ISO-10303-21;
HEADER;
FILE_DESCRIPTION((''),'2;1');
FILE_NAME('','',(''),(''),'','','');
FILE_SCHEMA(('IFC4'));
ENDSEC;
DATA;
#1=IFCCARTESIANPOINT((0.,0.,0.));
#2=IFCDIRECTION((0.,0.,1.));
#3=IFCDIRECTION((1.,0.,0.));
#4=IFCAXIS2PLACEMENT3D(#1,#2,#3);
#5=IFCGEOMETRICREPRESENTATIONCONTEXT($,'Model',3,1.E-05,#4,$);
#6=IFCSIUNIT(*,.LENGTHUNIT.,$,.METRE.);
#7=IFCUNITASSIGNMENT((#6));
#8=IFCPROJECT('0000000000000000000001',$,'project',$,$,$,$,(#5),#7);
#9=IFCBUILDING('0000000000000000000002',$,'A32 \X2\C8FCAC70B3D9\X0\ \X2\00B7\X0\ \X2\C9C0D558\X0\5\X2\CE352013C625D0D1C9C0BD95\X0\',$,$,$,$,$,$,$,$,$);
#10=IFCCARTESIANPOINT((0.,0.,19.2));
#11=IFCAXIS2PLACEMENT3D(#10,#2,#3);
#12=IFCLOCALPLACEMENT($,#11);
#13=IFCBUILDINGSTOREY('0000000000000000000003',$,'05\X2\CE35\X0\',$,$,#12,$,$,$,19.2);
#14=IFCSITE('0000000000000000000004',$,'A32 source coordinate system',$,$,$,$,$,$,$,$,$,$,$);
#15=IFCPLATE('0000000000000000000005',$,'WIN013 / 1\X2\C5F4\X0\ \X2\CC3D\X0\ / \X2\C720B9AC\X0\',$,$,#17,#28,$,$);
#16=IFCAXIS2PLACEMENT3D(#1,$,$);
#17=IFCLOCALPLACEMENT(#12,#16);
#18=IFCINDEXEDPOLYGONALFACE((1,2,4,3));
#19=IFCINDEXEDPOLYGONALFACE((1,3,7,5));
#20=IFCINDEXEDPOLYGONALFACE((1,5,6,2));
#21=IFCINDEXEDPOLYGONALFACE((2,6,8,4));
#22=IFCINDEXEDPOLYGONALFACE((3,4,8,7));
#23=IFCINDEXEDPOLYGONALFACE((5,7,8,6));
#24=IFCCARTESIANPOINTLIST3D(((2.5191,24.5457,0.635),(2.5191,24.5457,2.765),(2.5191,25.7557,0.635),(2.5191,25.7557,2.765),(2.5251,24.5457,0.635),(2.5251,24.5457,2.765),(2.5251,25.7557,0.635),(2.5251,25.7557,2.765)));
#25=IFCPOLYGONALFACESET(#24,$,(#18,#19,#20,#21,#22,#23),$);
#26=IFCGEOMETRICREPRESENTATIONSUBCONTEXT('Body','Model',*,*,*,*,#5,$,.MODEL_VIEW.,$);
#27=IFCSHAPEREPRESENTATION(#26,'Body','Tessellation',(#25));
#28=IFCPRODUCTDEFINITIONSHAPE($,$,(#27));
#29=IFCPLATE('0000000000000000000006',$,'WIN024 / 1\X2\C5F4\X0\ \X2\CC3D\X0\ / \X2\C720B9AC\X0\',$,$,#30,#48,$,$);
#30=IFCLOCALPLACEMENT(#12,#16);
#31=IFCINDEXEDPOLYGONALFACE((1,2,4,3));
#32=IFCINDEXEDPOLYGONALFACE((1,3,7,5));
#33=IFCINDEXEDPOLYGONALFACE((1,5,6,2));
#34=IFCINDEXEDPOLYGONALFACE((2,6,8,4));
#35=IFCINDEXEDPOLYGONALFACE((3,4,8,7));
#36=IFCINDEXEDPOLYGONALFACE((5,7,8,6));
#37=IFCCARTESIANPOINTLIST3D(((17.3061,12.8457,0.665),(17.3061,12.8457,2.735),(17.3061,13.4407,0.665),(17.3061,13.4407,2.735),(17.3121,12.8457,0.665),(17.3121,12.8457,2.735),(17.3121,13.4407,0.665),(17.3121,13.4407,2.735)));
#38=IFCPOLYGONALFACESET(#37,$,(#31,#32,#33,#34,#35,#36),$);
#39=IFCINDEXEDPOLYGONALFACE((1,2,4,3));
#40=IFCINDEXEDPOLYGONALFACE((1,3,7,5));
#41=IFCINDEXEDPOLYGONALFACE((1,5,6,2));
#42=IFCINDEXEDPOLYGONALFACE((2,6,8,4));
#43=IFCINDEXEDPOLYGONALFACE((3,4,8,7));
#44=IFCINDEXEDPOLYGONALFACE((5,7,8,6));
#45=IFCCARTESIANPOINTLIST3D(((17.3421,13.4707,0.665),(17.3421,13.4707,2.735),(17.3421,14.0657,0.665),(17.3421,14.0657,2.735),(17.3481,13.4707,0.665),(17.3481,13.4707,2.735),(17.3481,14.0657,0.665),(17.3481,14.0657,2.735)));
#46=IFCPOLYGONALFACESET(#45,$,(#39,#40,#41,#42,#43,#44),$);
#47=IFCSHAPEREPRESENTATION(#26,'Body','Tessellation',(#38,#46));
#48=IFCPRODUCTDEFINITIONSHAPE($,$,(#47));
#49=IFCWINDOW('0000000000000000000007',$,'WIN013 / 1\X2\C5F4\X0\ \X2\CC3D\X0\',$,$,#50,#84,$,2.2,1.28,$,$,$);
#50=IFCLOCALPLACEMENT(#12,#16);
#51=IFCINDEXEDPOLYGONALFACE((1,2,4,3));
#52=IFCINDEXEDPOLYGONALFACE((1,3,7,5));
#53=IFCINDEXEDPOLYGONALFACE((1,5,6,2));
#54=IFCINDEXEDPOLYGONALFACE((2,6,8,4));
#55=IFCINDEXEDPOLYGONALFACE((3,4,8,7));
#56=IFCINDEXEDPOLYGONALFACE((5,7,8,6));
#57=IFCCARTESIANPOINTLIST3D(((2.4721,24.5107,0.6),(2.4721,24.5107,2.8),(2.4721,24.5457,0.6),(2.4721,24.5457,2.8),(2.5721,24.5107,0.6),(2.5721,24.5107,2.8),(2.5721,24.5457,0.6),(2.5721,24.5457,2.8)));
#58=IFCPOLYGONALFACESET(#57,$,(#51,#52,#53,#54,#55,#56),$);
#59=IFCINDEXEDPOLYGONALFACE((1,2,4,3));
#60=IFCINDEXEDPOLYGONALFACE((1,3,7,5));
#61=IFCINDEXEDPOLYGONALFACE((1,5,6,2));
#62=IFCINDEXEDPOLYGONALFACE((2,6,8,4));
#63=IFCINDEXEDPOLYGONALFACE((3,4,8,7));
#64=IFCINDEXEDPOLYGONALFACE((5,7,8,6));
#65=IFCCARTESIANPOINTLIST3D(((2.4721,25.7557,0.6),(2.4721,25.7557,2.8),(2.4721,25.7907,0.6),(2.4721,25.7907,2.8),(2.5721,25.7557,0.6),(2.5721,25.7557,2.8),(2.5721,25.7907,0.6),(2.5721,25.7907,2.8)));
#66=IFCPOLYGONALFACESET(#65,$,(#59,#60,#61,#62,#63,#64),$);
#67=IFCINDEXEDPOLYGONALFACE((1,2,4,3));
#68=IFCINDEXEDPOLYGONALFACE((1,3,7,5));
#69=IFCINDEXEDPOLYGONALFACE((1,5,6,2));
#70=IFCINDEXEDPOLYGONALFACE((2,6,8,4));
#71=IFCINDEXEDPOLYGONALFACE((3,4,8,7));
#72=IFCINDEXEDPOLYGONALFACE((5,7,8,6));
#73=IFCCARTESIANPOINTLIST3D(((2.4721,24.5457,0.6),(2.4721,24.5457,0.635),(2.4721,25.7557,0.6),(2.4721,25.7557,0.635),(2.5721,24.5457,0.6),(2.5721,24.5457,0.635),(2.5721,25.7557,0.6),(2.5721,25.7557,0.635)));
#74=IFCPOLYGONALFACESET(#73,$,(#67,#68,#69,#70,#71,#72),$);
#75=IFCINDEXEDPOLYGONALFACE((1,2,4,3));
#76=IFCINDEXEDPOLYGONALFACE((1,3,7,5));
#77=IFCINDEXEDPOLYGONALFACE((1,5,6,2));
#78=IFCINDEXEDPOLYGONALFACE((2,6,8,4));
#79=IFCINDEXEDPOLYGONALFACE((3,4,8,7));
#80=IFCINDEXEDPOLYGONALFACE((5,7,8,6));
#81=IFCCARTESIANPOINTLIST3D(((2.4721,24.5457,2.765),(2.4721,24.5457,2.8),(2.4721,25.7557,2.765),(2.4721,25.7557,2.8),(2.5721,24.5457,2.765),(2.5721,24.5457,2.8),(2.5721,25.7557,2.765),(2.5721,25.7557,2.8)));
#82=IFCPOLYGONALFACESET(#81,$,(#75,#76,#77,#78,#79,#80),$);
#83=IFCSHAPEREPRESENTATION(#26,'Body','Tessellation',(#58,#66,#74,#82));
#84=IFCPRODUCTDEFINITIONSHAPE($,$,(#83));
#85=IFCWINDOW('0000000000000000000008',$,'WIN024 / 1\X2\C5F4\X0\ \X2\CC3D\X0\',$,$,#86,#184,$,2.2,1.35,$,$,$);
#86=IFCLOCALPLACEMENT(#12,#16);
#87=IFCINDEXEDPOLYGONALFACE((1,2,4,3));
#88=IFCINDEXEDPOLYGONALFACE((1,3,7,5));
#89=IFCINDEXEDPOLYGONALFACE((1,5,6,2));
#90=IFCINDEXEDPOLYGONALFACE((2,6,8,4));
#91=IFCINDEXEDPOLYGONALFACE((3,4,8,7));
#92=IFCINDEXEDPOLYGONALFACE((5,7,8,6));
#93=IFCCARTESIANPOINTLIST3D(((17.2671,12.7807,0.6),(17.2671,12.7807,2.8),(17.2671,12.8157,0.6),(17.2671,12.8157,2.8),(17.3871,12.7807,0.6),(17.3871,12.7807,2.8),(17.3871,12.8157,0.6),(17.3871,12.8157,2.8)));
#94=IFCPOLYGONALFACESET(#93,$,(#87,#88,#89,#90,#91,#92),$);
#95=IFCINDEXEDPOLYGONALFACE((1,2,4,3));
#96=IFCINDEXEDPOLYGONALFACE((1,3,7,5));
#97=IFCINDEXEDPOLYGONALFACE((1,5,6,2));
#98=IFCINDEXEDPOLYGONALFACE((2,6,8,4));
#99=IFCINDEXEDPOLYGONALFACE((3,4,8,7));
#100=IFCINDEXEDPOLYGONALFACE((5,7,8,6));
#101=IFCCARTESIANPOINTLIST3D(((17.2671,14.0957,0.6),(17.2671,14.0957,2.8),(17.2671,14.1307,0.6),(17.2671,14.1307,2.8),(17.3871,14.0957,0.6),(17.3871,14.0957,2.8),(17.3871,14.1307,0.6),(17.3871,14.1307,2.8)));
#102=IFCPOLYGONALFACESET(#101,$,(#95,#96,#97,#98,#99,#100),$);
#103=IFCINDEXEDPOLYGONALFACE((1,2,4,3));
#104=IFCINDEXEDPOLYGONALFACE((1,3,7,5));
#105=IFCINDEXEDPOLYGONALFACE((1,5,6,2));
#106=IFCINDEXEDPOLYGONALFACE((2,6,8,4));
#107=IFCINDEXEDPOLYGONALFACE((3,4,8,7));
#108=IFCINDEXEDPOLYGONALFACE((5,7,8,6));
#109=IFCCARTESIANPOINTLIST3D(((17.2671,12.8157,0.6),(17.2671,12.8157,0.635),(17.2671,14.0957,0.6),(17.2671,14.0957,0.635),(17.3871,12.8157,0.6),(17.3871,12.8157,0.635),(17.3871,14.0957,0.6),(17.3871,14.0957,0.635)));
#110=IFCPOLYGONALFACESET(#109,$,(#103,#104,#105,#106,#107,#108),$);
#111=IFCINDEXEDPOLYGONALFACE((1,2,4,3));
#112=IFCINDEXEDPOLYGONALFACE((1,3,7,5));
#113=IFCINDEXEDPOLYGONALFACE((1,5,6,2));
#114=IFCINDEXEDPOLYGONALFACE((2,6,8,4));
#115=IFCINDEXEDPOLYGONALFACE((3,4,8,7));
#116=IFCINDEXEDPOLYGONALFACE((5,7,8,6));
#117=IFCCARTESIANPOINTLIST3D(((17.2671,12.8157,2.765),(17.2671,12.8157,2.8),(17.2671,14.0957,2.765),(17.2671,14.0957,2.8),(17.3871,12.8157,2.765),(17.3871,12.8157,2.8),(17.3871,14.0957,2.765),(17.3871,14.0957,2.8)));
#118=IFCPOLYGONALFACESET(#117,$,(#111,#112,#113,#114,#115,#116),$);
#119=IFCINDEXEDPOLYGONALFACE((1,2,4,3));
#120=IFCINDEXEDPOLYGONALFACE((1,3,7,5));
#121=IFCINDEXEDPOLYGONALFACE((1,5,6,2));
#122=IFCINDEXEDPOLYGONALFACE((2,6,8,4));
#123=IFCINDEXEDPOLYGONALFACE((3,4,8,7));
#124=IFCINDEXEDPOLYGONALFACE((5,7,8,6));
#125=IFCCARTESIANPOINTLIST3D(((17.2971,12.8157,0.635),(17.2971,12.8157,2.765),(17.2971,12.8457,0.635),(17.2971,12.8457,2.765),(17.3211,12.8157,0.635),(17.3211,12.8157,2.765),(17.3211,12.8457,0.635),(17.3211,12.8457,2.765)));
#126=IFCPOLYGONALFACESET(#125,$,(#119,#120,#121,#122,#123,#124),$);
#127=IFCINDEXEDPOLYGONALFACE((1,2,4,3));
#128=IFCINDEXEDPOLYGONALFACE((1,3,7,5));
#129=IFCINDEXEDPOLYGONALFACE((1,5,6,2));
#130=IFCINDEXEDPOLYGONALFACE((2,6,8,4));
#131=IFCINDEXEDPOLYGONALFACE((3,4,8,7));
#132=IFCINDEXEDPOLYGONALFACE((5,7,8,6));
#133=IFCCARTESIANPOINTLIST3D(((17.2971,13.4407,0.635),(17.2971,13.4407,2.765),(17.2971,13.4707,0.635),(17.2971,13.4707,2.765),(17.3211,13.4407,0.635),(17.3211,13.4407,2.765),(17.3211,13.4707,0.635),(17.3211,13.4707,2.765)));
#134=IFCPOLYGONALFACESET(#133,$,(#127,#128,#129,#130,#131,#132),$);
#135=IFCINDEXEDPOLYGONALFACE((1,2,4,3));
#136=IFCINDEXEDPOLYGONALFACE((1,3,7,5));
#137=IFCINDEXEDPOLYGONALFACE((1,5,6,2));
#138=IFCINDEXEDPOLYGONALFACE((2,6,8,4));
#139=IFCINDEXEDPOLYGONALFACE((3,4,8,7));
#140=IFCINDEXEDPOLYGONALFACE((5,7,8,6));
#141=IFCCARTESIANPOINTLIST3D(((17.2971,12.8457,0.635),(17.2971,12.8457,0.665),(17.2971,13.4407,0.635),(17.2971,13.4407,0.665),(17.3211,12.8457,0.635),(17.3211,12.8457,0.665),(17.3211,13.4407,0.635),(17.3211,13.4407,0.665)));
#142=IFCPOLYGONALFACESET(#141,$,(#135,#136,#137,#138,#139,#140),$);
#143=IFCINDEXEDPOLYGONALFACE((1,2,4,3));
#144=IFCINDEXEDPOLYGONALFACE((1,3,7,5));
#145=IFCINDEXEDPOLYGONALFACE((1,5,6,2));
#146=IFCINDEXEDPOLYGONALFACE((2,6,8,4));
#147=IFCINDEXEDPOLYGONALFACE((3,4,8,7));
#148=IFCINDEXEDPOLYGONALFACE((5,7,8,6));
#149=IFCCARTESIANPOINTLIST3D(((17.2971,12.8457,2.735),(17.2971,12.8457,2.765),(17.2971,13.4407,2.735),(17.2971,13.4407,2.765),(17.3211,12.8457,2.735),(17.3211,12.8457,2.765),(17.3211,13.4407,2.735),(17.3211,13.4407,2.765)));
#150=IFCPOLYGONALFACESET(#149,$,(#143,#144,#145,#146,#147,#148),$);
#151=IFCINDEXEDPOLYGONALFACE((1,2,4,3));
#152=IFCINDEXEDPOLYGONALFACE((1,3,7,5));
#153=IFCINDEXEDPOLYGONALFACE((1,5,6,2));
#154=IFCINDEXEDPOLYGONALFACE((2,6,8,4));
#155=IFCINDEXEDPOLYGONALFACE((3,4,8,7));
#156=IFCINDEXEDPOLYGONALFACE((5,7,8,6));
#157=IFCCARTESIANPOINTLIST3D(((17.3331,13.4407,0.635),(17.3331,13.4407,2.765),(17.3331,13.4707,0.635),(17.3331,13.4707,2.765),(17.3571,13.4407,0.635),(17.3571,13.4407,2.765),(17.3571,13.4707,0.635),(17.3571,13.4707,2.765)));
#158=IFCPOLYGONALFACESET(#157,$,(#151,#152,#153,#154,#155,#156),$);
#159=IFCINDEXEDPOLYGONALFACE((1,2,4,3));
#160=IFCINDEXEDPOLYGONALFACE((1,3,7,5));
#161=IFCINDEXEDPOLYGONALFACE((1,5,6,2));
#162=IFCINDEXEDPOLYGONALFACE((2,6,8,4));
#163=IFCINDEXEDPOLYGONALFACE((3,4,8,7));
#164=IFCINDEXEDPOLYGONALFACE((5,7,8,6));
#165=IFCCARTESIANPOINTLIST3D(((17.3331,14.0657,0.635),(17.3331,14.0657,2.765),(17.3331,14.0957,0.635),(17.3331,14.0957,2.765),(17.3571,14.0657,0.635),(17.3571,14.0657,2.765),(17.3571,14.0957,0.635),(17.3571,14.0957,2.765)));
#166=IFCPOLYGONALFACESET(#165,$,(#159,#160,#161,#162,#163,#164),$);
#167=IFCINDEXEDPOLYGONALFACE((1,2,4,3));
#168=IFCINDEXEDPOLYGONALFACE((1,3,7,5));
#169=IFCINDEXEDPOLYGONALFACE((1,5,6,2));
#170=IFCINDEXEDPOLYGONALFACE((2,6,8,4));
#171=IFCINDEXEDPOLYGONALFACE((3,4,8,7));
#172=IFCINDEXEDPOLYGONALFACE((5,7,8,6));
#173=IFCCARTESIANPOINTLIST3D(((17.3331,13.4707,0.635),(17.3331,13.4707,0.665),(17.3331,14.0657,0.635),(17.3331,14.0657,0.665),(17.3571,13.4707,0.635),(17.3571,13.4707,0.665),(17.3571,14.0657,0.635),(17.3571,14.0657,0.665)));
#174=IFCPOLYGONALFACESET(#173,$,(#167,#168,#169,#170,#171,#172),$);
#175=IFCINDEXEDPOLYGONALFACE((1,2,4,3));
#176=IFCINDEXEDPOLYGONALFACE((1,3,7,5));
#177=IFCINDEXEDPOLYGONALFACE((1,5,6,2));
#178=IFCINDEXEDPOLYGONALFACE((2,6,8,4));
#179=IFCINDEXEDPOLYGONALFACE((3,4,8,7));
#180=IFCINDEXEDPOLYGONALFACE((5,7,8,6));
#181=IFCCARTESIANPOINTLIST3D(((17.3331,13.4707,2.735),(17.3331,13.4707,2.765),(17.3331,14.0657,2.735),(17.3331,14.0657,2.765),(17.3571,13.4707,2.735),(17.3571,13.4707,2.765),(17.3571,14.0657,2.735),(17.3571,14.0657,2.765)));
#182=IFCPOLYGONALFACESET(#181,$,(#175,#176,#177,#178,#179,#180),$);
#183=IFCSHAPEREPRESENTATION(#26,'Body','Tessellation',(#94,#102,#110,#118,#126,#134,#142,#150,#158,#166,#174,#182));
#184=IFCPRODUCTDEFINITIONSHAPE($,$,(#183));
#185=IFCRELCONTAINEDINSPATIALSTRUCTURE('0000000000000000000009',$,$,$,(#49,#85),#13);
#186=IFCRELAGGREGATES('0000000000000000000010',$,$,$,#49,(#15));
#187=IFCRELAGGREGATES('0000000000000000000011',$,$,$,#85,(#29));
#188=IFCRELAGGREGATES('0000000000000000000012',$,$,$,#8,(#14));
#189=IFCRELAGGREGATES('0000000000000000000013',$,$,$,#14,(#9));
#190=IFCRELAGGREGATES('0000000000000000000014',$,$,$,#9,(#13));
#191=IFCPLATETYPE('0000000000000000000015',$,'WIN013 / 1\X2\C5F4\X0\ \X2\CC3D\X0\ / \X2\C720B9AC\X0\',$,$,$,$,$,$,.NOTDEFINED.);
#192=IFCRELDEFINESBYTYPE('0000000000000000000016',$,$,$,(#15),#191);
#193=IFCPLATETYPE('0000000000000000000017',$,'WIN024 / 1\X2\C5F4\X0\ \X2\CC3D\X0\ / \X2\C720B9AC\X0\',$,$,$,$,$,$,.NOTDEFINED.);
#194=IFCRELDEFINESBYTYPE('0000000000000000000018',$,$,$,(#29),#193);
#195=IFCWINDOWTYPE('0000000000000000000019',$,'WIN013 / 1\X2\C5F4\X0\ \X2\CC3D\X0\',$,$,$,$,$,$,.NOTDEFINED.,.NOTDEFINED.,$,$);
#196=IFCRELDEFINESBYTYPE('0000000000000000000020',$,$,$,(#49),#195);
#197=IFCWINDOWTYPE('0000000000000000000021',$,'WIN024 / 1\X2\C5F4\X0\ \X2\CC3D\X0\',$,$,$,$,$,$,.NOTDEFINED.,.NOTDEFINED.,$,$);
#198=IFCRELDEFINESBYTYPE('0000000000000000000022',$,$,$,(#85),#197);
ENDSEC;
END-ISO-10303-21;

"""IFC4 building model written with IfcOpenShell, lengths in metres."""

from ifc_helpers import new_model, si_unit, frame, origin, origin_with_axes, place, context, subcontext, project, spatial, polyline, outline, extrude, source, transform, mapped, type_object, type_shapes, element, aggregate, save


model = new_model("IFC4")

# Units and contexts
model_context = context("Model", 3, precision=1e-05, world=origin_with_axes())
body_context = subcontext(model_context, "Body", "Model", "MODEL_VIEW")
ifc_project = project(units=[si_unit("LENGTHUNIT", "METRE")], contexts=[model_context])

# Plates
plate_type_1 = type_object("IfcPlateType", Name="WIN013 / 1열 창 / 유리", PredefinedType="NOTDEFINED")
shared_shape_1 = source(origin(), body_context, "Body", "SweptSolid", [
    extrude(outline(polyline([(2.5191, 24.5457), (2.5191, 25.7557), (2.5251, 25.7557), (2.5251, 24.5457), (2.5191, 24.5457)])), frame((0.0, 0.0, 0.635)), (0.0, 0.0, 1.0), 2.13),
])
type_shapes(plate_type_1, [shared_shape_1])
storey_placement = place(None, frame((0.0, 0.0, 19.2), z_axis=(0.0, 0.0, 1.0), x_axis=(1.0, 0.0, 0.0)))
window_1_placement = place(storey_placement, origin_with_axes())
plate_1_placement = place(window_1_placement, origin_with_axes())
plate_1 = element("IfcPlate", 1, at=plate_1_placement, type_object=plate_type_1, Name="WIN013 / 1열 창 / 유리", context=body_context, shape_type="MappedRepresentation", body=[
    mapped(shared_shape_1, transform((0.0, 0.0, 0.0), scale=1.0)),
])
plate_type_2 = type_object("IfcPlateType", Name="WIN024 / 1열 창 / 유리", PredefinedType="NOTDEFINED")
shared_shape_2 = source(origin(), body_context, "Body", "SweptSolid", [
    extrude(outline(polyline([(17.3061, 12.8457), (17.3061, 13.4407), (17.3121, 13.4407), (17.3121, 12.8457), (17.3061, 12.8457)])), frame((0.0, 0.0, 0.665)), (0.0, 0.0, 1.0), 2.07),
    extrude(outline(polyline([(17.3421, 13.4707), (17.3421, 14.0657), (17.3481, 14.0657), (17.3481, 13.4707), (17.3421, 13.4707)])), frame((0.0, 0.0, 0.665)), (0.0, 0.0, 1.0), 2.07),
])
type_shapes(plate_type_2, [shared_shape_2])
window_2_placement = place(storey_placement, origin_with_axes())
plate_2_placement = place(window_2_placement, origin_with_axes())
plate_2 = element("IfcPlate", 2, at=plate_2_placement, type_object=plate_type_2, Name="WIN024 / 1열 창 / 유리", context=body_context, shape_type="MappedRepresentation", body=[
    mapped(shared_shape_2, transform((0.0, 0.0, 0.0), scale=1.0)),
])

# Site, building, storey
site = spatial("IfcSite", under=ifc_project, Name="A32 source coordinate system")
building = spatial("IfcBuilding", under=site, Name="A32 주거동 · 지하5층–옥탑지붕")
storey = spatial("IfcBuildingStorey", under=building, at=storey_placement, Name="05층", Elevation=19.2)

# Windows
window_type_1 = type_object("IfcWindowType", Name="WIN013 / 1열 창", PartitioningType="NOTDEFINED", PredefinedType="NOTDEFINED")
shared_shape_3 = source(origin(), body_context, "Body", "SweptSolid", [
    extrude(outline(polyline([(2.4721, 24.5107), (2.4721, 24.5457), (2.5721, 24.5457), (2.5721, 24.5107), (2.4721, 24.5107)])), frame((0.0, 0.0, 0.6)), (0.0, 0.0, 1.0), 2.2),
    extrude(outline(polyline([(2.4721, 25.7557), (2.4721, 25.7907), (2.5721, 25.7907), (2.5721, 25.7557), (2.4721, 25.7557)])), frame((0.0, 0.0, 0.6)), (0.0, 0.0, 1.0), 2.2),
    extrude(outline(polyline([(2.4721, 24.5457), (2.4721, 25.7557), (2.5721, 25.7557), (2.5721, 24.5457), (2.4721, 24.5457)])), frame((0.0, 0.0, 0.6)), (0.0, 0.0, 1.0), 0.035),
    extrude(outline(polyline([(2.4721, 24.5457), (2.4721, 25.7557), (2.5721, 25.7557), (2.5721, 24.5457), (2.4721, 24.5457)])), frame((0.0, 0.0, 2.765)), (0.0, 0.0, 1.0), 0.035),
])
type_shapes(window_type_1, [shared_shape_3])
window_1 = element("IfcWindow", 3, at=window_1_placement, inside=storey, type_object=window_type_1, Name="WIN013 / 1열 창", OverallHeight=2.2, OverallWidth=1.28, context=body_context, shape_type="MappedRepresentation", body=[
    mapped(shared_shape_3, transform((0.0, 0.0, 0.0), scale=1.0)),
])
aggregate(window_1, [plate_1])
window_type_2 = type_object("IfcWindowType", Name="WIN024 / 1열 창", PartitioningType="NOTDEFINED", PredefinedType="NOTDEFINED")
shared_shape_4 = source(origin(), body_context, "Body", "SweptSolid", [
    extrude(outline(polyline([(17.2671, 12.7807), (17.2671, 12.8157), (17.3871, 12.8157), (17.3871, 12.7807), (17.2671, 12.7807)])), frame((0.0, 0.0, 0.6)), (0.0, 0.0, 1.0), 2.2),
    extrude(outline(polyline([(17.2671, 14.0957), (17.2671, 14.1307), (17.3871, 14.1307), (17.3871, 14.0957), (17.2671, 14.0957)])), frame((0.0, 0.0, 0.6)), (0.0, 0.0, 1.0), 2.2),
    extrude(outline(polyline([(17.2671, 12.8157), (17.2671, 14.0957), (17.3871, 14.0957), (17.3871, 12.8157), (17.2671, 12.8157)])), frame((0.0, 0.0, 0.6)), (0.0, 0.0, 1.0), 0.035),
    extrude(outline(polyline([(17.2671, 12.8157), (17.2671, 14.0957), (17.3871, 14.0957), (17.3871, 12.8157), (17.2671, 12.8157)])), frame((0.0, 0.0, 2.765)), (0.0, 0.0, 1.0), 0.035),
    extrude(outline(polyline([(17.2971, 12.8157), (17.2971, 12.8457), (17.3211, 12.8457), (17.3211, 12.8157), (17.2971, 12.8157)])), frame((0.0, 0.0, 0.635)), (0.0, 0.0, 1.0), 2.13),
    extrude(outline(polyline([(17.2971, 13.4407), (17.2971, 13.4707), (17.3211, 13.4707), (17.3211, 13.4407), (17.2971, 13.4407)])), frame((0.0, 0.0, 0.635)), (0.0, 0.0, 1.0), 2.13),
    extrude(outline(polyline([(17.2971, 12.8457), (17.2971, 13.4407), (17.3211, 13.4407), (17.3211, 12.8457), (17.2971, 12.8457)])), frame((0.0, 0.0, 0.635)), (0.0, 0.0, 1.0), 0.03),
    extrude(outline(polyline([(17.2971, 12.8457), (17.2971, 13.4407), (17.3211, 13.4407), (17.3211, 12.8457), (17.2971, 12.8457)])), frame((0.0, 0.0, 2.735)), (0.0, 0.0, 1.0), 0.03),
    extrude(outline(polyline([(17.3331, 13.4407), (17.3331, 13.4707), (17.3571, 13.4707), (17.3571, 13.4407), (17.3331, 13.4407)])), frame((0.0, 0.0, 0.635)), (0.0, 0.0, 1.0), 2.13),
    extrude(outline(polyline([(17.3331, 14.0657), (17.3331, 14.0957), (17.3571, 14.0957), (17.3571, 14.0657), (17.3331, 14.0657)])), frame((0.0, 0.0, 0.635)), (0.0, 0.0, 1.0), 2.13),
    extrude(outline(polyline([(17.3331, 13.4707), (17.3331, 14.0657), (17.3571, 14.0657), (17.3571, 13.4707), (17.3331, 13.4707)])), frame((0.0, 0.0, 0.635)), (0.0, 0.0, 1.0), 0.03),
    extrude(outline(polyline([(17.3331, 13.4707), (17.3331, 14.0657), (17.3571, 14.0657), (17.3571, 13.4707), (17.3331, 13.4707)])), frame((0.0, 0.0, 2.735)), (0.0, 0.0, 1.0), 0.03),
])
type_shapes(window_type_2, [shared_shape_4])
window_2 = element("IfcWindow", 4, at=window_2_placement, inside=storey, type_object=window_type_2, Name="WIN024 / 1열 창", OverallHeight=2.2, OverallWidth=1.35, context=body_context, shape_type="MappedRepresentation", body=[
    mapped(shared_shape_4, transform((0.0, 0.0, 0.0), scale=1.0)),
])
aggregate(window_2, [plate_2])

save(model, "model.ifc")
